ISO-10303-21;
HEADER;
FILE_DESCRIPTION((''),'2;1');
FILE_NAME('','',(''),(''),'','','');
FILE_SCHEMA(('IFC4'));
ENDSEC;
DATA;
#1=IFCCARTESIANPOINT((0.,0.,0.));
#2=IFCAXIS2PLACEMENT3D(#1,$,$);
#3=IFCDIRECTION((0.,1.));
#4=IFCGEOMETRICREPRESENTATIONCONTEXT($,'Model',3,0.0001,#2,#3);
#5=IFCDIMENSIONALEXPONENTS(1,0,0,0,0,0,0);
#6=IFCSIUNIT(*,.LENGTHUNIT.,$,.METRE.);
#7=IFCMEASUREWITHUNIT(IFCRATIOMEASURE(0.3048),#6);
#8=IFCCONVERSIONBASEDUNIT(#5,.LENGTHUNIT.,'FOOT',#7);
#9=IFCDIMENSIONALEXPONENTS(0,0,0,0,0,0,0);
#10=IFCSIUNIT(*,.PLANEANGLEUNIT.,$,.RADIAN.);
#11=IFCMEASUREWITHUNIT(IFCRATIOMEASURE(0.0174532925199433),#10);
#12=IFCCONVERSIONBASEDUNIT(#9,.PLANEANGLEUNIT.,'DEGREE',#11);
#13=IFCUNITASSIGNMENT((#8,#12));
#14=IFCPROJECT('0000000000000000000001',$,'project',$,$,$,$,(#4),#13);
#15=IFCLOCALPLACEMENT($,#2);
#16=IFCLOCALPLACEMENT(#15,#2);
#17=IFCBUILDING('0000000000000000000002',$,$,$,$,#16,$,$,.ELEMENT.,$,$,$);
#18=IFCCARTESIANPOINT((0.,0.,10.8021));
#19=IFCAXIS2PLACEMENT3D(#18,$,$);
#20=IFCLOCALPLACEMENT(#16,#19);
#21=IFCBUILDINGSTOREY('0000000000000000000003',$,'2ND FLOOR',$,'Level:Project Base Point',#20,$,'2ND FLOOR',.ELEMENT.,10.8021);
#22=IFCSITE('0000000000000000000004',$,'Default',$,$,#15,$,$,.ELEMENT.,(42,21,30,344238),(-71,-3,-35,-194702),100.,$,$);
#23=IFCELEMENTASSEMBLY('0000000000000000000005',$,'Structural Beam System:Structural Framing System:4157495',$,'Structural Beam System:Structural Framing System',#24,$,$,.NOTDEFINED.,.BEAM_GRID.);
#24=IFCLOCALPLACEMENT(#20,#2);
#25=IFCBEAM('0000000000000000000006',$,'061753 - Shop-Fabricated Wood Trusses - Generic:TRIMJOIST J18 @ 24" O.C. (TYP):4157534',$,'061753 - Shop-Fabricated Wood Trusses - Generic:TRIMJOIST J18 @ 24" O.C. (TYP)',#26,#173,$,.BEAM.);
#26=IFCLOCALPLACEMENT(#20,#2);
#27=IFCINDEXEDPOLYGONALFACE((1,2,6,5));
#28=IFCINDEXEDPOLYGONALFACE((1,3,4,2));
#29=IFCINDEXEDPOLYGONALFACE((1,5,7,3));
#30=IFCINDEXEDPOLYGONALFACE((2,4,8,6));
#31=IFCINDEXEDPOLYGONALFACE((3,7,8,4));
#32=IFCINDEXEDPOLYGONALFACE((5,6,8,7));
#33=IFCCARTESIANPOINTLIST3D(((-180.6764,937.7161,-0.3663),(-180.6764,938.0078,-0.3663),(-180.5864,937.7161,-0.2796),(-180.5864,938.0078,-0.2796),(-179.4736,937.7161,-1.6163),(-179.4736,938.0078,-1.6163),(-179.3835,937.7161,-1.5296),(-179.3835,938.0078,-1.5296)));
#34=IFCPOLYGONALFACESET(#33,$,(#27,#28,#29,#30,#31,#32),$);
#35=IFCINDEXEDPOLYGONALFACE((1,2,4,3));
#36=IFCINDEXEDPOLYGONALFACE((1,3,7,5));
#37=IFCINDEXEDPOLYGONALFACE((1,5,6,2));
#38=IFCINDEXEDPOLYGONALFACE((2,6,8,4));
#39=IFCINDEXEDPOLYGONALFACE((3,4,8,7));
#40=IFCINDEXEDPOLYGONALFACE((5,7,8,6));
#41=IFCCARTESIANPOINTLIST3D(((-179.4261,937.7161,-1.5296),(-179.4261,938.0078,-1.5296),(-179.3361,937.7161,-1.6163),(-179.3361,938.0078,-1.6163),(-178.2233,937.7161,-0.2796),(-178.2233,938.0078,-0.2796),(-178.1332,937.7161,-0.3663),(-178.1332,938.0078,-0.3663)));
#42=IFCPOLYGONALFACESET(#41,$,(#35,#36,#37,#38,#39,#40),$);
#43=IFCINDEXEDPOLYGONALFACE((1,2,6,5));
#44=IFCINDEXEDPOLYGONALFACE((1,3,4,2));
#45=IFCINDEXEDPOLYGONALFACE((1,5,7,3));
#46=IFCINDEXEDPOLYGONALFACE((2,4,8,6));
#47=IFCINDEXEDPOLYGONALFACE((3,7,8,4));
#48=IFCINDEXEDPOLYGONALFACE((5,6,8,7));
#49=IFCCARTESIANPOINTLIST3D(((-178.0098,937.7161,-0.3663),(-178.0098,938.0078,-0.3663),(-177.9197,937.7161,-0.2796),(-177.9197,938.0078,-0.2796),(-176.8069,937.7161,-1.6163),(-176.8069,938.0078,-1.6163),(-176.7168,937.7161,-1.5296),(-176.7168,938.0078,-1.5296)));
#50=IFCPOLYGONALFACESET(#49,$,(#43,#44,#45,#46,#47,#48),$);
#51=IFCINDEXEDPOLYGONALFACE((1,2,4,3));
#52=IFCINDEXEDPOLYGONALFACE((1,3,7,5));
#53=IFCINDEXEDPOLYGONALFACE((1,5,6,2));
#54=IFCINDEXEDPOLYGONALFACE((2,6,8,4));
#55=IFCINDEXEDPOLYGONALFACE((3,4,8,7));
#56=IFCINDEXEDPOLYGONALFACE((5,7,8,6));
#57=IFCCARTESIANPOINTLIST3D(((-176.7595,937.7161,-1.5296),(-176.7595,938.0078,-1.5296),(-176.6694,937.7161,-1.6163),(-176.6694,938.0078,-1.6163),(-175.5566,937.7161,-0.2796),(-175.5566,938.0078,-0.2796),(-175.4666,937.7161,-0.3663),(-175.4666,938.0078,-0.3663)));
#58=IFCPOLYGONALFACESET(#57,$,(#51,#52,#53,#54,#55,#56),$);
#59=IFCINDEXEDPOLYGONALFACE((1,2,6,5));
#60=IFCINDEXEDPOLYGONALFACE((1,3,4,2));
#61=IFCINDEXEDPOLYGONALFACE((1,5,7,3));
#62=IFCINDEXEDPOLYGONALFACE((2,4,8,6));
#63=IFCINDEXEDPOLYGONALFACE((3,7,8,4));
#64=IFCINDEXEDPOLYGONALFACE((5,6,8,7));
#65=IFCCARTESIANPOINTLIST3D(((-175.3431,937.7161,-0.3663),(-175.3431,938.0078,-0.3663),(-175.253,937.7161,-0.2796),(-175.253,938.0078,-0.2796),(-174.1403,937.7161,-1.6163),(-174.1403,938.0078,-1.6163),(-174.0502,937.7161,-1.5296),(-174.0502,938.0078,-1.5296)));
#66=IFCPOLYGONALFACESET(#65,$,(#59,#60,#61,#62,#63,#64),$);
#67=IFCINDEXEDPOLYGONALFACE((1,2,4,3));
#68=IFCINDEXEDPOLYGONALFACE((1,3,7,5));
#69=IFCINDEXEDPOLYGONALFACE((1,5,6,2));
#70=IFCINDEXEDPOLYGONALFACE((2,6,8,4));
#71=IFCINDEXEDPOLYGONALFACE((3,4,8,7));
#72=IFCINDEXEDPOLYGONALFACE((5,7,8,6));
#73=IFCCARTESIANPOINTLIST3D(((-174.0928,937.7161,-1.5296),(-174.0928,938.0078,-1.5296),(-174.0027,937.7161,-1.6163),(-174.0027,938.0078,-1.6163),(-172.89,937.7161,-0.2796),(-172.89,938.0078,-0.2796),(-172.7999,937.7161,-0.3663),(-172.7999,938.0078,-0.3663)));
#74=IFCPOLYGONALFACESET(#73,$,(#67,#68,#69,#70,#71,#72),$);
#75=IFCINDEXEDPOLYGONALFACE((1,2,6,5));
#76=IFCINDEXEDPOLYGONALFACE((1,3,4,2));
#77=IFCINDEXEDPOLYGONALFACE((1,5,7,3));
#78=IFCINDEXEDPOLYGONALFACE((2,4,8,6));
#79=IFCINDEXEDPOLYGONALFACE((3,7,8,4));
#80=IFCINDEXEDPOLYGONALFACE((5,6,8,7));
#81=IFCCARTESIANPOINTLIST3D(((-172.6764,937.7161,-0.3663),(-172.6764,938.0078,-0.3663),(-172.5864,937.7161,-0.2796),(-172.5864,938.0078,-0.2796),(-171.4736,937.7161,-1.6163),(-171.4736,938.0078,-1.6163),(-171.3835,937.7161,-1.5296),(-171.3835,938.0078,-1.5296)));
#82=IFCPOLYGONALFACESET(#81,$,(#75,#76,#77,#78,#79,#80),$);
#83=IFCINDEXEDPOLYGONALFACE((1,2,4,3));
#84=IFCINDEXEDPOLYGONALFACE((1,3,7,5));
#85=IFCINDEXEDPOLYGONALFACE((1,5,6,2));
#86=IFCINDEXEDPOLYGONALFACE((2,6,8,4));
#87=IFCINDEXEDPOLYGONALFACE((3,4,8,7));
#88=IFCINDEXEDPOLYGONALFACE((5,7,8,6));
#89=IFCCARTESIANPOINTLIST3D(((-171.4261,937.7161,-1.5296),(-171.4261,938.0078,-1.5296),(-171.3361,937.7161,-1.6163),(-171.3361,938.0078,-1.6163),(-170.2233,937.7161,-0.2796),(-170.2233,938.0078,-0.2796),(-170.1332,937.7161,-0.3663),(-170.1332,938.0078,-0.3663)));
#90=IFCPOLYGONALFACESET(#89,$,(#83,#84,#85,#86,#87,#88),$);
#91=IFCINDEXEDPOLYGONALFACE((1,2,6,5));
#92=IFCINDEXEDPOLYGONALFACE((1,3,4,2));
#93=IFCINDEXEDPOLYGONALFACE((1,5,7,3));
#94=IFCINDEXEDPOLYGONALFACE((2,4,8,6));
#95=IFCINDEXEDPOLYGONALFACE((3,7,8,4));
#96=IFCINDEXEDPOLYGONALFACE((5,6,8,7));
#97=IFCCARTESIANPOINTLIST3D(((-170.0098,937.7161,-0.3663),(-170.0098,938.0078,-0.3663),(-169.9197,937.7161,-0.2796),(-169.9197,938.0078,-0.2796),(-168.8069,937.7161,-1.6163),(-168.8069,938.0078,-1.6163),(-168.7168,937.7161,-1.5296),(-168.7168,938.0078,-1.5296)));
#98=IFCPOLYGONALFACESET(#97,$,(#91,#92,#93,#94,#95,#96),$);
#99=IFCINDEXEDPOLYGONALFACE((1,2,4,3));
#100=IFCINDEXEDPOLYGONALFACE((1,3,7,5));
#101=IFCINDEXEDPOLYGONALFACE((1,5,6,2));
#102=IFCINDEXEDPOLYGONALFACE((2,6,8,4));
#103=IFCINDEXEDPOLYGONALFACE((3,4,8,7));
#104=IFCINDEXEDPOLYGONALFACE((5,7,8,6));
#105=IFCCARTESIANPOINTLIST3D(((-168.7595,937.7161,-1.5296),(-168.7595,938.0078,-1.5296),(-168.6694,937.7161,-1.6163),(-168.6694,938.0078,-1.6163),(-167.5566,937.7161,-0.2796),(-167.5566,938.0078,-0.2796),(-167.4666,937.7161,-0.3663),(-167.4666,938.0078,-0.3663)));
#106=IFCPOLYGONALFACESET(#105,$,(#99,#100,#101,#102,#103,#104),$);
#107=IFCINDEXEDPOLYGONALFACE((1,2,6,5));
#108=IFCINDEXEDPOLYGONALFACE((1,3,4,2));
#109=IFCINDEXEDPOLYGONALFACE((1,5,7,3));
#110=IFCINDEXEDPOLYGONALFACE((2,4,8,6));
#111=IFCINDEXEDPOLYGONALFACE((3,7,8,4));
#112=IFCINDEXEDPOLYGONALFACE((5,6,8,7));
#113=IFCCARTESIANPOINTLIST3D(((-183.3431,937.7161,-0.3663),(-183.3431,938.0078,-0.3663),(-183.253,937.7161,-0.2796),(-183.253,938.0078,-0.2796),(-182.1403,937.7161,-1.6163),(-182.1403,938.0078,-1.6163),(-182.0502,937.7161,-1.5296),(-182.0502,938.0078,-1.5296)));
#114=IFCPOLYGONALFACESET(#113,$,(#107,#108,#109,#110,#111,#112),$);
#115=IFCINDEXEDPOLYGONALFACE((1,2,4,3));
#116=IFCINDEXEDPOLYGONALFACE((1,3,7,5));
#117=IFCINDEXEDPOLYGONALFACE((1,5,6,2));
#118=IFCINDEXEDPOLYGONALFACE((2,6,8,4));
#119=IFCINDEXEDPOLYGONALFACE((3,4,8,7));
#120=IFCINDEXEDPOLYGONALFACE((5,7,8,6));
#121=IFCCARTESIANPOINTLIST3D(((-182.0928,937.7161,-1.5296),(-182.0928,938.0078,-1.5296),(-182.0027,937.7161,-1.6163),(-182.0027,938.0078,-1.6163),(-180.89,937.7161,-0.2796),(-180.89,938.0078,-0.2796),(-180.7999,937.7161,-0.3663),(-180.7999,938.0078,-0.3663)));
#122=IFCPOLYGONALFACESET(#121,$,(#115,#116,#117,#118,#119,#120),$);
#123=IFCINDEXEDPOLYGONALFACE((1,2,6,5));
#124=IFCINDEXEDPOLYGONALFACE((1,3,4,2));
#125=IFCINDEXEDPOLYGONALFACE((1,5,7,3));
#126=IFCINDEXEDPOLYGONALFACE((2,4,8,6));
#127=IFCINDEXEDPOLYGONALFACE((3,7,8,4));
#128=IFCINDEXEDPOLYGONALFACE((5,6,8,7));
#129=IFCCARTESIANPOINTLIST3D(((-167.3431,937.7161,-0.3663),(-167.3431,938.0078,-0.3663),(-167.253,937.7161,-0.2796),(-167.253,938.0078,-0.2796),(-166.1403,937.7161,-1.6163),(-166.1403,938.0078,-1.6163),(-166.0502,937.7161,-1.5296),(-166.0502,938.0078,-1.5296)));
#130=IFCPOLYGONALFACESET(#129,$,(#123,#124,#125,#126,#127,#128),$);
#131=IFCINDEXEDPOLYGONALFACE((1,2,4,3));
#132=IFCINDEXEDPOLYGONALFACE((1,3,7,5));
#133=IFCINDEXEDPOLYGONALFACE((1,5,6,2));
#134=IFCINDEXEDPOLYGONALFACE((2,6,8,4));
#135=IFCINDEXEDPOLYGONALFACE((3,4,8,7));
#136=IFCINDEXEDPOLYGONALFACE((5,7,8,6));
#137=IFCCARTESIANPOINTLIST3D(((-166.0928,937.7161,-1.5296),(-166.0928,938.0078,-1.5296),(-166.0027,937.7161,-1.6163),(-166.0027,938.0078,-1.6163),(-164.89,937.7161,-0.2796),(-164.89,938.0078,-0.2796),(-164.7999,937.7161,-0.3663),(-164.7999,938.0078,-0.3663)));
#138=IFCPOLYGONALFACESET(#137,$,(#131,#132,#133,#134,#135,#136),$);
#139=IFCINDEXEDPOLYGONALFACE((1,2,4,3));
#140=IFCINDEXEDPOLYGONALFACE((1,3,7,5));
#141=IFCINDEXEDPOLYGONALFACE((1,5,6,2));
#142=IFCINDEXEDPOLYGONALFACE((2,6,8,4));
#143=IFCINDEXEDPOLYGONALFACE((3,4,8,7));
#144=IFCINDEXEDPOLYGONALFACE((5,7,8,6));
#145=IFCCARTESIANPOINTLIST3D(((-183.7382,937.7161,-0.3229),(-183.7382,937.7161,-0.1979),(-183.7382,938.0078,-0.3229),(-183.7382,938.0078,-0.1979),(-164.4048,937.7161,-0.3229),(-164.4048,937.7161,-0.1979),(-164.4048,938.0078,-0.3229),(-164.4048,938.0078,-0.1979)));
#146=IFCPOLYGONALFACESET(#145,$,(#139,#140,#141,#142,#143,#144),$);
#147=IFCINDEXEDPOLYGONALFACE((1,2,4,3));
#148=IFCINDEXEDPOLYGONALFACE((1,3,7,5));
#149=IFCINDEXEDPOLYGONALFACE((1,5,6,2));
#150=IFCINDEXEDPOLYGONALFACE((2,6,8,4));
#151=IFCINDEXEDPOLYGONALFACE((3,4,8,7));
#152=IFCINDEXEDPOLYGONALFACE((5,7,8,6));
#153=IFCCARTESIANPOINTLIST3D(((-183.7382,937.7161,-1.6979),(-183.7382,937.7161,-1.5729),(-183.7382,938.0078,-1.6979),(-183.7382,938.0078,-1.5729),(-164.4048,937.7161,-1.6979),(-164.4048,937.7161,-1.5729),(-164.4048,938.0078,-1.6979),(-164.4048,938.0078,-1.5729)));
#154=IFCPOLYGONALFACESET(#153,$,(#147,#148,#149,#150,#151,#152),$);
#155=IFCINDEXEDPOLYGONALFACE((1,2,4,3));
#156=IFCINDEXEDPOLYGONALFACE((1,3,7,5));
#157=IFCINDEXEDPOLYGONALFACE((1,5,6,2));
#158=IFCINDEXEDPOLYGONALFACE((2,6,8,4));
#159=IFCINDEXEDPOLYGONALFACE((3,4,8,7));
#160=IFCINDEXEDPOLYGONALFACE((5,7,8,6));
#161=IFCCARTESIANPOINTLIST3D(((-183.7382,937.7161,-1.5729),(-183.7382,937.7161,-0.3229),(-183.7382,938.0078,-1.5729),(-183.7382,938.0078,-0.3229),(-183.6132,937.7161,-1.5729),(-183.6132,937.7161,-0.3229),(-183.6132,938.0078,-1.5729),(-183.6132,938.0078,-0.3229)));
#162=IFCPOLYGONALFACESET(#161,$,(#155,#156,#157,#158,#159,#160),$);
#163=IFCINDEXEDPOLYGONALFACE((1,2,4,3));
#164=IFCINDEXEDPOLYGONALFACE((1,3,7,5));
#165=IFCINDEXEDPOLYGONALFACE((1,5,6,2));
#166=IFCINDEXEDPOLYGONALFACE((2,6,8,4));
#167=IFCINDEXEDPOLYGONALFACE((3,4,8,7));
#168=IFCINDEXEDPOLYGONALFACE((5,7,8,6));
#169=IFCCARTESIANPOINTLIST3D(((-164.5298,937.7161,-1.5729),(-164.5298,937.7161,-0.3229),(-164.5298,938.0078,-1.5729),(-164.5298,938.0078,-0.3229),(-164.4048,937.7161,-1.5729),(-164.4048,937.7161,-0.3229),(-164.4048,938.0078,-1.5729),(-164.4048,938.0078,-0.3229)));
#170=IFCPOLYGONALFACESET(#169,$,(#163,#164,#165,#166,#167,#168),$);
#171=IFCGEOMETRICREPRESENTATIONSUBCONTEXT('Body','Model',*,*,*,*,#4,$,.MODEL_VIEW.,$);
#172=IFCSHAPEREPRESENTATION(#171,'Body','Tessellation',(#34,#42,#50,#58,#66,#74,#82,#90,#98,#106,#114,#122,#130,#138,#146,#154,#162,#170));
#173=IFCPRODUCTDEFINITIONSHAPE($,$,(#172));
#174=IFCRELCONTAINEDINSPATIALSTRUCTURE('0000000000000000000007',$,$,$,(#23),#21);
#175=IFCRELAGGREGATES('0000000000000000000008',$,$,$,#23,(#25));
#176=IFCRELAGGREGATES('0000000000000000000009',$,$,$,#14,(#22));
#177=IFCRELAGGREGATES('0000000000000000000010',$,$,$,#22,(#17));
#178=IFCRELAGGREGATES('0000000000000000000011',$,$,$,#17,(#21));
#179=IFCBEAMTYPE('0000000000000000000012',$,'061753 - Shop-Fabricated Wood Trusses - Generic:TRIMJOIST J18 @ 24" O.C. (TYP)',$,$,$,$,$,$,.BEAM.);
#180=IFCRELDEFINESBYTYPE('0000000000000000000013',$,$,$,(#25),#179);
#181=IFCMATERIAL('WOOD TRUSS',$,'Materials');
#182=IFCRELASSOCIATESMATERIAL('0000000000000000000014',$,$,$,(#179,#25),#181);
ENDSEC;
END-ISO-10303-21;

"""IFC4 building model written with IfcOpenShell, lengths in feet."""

from ifc_helpers import new_model, entity, si_unit, converted_unit, direction, frame, frame_2d, origin, origin_2d_with_axis, place, context, subcontext, project, spatial, rectangle, extrude, source, transform, mapped, material, material_profile, profile_set, profile_usage, type_object, type_shapes, element, aggregate, save


model = new_model("IFC4")

# Units and contexts
model_context = context("Model", 3, precision=0.0001, world=origin(), true_north=direction((0.0, 1.0)))
body_context = subcontext(model_context, "Body", "Model", "MODEL_VIEW")
ifc_project = project(units=[converted_unit("LENGTHUNIT", "FOOT", entity("IfcRatioMeasure", 0.3048), si_unit("LENGTHUNIT", "METRE"), dimensions=[1, 0, 0, 0, 0, 0, 0]), converted_unit("PLANEANGLEUNIT", "DEGREE", entity("IfcRatioMeasure", 0.0174532925199433), si_unit("PLANEANGLEUNIT", "RADIAN"), dimensions=[0, 0, 0, 0, 0, 0, 0])], contexts=[model_context])

# Site, building, storey
site_placement = place(None, origin())
site = spatial("IfcSite", under=ifc_project, at=site_placement, Name="Default", CompositionType="ELEMENT", RefLatitude=(42, 21, 30, 344238), RefLongitude=(-71, -3, -35, -194702), RefElevation=100.0)
building_placement = place(site_placement, origin())
building = spatial("IfcBuilding", under=site, at=building_placement, CompositionType="ELEMENT")
storey_placement = place(building_placement, frame((0.0, 0.0, 10.8021)))
storey = spatial("IfcBuildingStorey", under=building, at=storey_placement, Name="2ND FLOOR", ObjectType="Level:Project Base Point", LongName="2ND FLOOR", CompositionType="ELEMENT", Elevation=10.8021)

# Element assembly, beam
ifc_material_1 = material(Name="WOOD TRUSS", Category="Materials")
ifc_material_profile_1 = material_profile(ifc_material_1, rectangle(XDim=1.7347, YDim=0.125, at=frame_2d((0.0, 0.0), x_axis=(1.0, 0.0))), Name="TRIMJOIST J18 @ 24\" O.C. (TYP)")
ifc_material_profile_2 = material_profile(ifc_material_1, rectangle(XDim=1.7347, YDim=0.125, at=frame_2d((0.0, 0.0), x_axis=(1.0, 0.0))), Name="TRIMJOIST J18 @ 24\" O.C. (TYP)")
ifc_material_profile_3 = material_profile(ifc_material_1, rectangle(XDim=1.7347, YDim=0.125, at=frame_2d((0.0, 0.0), x_axis=(1.0, 0.0))), Name="TRIMJOIST J18 @ 24\" O.C. (TYP)")
ifc_material_profile_4 = material_profile(ifc_material_1, rectangle(XDim=1.7347, YDim=0.125, at=frame_2d((0.0, 0.0), x_axis=(1.0, 0.0))), Name="TRIMJOIST J18 @ 24\" O.C. (TYP)")
ifc_material_profile_5 = material_profile(ifc_material_1, rectangle(XDim=1.7347, YDim=0.125, at=frame_2d((0.0, 0.0), x_axis=(1.0, 0.0))), Name="TRIMJOIST J18 @ 24\" O.C. (TYP)")
ifc_material_profile_6 = material_profile(ifc_material_1, rectangle(XDim=1.7347, YDim=0.125, at=frame_2d((0.0, 0.0), x_axis=(1.0, 0.0))), Name="TRIMJOIST J18 @ 24\" O.C. (TYP)")
ifc_material_profile_7 = material_profile(ifc_material_1, rectangle(XDim=1.7347, YDim=0.125, at=frame_2d((0.0, 0.0), x_axis=(1.0, 0.0))), Name="TRIMJOIST J18 @ 24\" O.C. (TYP)")
ifc_material_profile_8 = material_profile(ifc_material_1, rectangle(XDim=1.7347, YDim=0.125, at=frame_2d((0.0, 0.0), x_axis=(1.0, 0.0))), Name="TRIMJOIST J18 @ 24\" O.C. (TYP)")
ifc_material_profile_9 = material_profile(ifc_material_1, rectangle(XDim=1.7347, YDim=0.125, at=frame_2d((0.0, 0.0), x_axis=(1.0, 0.0))), Name="TRIMJOIST J18 @ 24\" O.C. (TYP)")
ifc_material_profile_10 = material_profile(ifc_material_1, rectangle(XDim=1.7347, YDim=0.125, at=origin_2d_with_axis()), Name="TRIMJOIST J18 @ 24\" O.C. (TYP)")
ifc_material_profile_11 = material_profile(ifc_material_1, rectangle(XDim=0.125, YDim=0.2917, at=origin_2d_with_axis()), Name="TRIMJOIST J18 @ 24\" O.C. (TYP)")
ifc_material_profile_12 = material_profile(ifc_material_1, rectangle(XDim=0.125, YDim=0.2917, at=origin_2d_with_axis()), Name="TRIMJOIST J18 @ 24\" O.C. (TYP)")
ifc_material_profile_13 = material_profile(ifc_material_1, rectangle(XDim=1.25, YDim=0.2917, at=origin_2d_with_axis()), Name="TRIMJOIST J18 @ 24\" O.C. (TYP)")
ifc_material_profile_14 = material_profile(ifc_material_1, rectangle(XDim=1.25, YDim=0.2917, at=origin_2d_with_axis()), Name="TRIMJOIST J18 @ 24\" O.C. (TYP)")
ifc_profile_set_1 = profile_set([ifc_material_profile_1, ifc_material_profile_2, ifc_material_profile_3, ifc_material_profile_4, ifc_material_profile_5, ifc_material_profile_6, ifc_material_profile_7, ifc_material_profile_8, ifc_material_profile_9, ifc_material_profile_10, ifc_material_profile_11, ifc_material_profile_12, ifc_material_profile_13, ifc_material_profile_14], Name="TRIMJOIST J18 @ 24\" O.C. (TYP)")
assembly_1_placement = place(storey_placement, origin())
assembly_1 = element("IfcElementAssembly", 1, at=assembly_1_placement, inside=storey, Name="Structural Beam System:Structural Framing System:4157495", ObjectType="Structural Beam System:Structural Framing System", AssemblyPlace="NOTDEFINED", PredefinedType="BEAM_GRID")
beam_type_1 = type_object("IfcBeamType", Name="061753 - Shop-Fabricated Wood Trusses - Generic:TRIMJOIST J18 @ 24\" O.C. (TYP)", PredefinedType="BEAM", material=ifc_profile_set_1)
shared_shape_1 = source(origin(), body_context, "Body", "SweptSolid", [
    extrude(rectangle(XDim=1.7347, YDim=0.125, at=frame_2d((0.0, 0.0), x_axis=(1.0, 0.0))), frame((5.9585, -0.1458, 0.0), z_axis=(0.0, 1.0, 0.0), x_axis=(0.693383, 0.0, 0.720569)), (0.0, 0.0, 1.0), 0.2917),
    extrude(rectangle(XDim=1.7347, YDim=0.125, at=origin_2d_with_axis()), frame((4.7082, -0.1458, 0.0), z_axis=(0.0, 1.0, 0.0), x_axis=(0.693383, 0.0, -0.720569)), (0.0, 0.0, 1.0), 0.2917),
    extrude(rectangle(XDim=1.7347, YDim=0.125, at=frame_2d((0.0, 0.0), x_axis=(1.0, 0.0))), frame((3.2918, -0.1458, 0.0), z_axis=(0.0, 1.0, 0.0), x_axis=(0.693383, 0.0, 0.720569)), (0.0, 0.0, 1.0), 0.2917),
    extrude(rectangle(XDim=1.7347, YDim=0.125, at=frame_2d((0.0, 0.0), x_axis=(1.0, 0.0))), frame((2.0415, -0.1458, 0.0), z_axis=(0.0, 1.0, 0.0), x_axis=(0.693383, 0.0, -0.720569)), (0.0, 0.0, 1.0), 0.2917),
    extrude(rectangle(XDim=1.7347, YDim=0.125, at=frame_2d((0.0, 0.0), x_axis=(1.0, 0.0))), frame((0.6251, -0.1458, 0.0), z_axis=(0.0, 1.0, 0.0), x_axis=(0.693383, 0.0, 0.720569)), (0.0, 0.0, 1.0), 0.2917),
    extrude(rectangle(XDim=1.7347, YDim=0.125, at=frame_2d((0.0, 0.0), x_axis=(1.0, 0.0))), frame((-0.6251, -0.1458, 0.0), z_axis=(0.0, 1.0, 0.0), x_axis=(0.693383, 0.0, -0.720569)), (0.0, 0.0, 1.0), 0.2917),
    extrude(rectangle(XDim=1.7347, YDim=0.125, at=frame_2d((0.0, 0.0), x_axis=(1.0, 0.0))), frame((-2.0415, -0.1458, 0.0), z_axis=(0.0, 1.0, 0.0), x_axis=(0.693383, 0.0, 0.720569)), (0.0, 0.0, 1.0), 0.2917),
    extrude(rectangle(XDim=1.7347, YDim=0.125, at=origin_2d_with_axis()), frame((-3.2918, -0.1458, 0.0), z_axis=(0.0, 1.0, 0.0), x_axis=(0.693383, 0.0, -0.720569)), (0.0, 0.0, 1.0), 0.2917),
    extrude(rectangle(XDim=1.7347, YDim=0.125, at=frame_2d((0.0, 0.0), x_axis=(1.0, 0.0))), frame((-4.7082, -0.1458, 0.0), z_axis=(0.0, 1.0, 0.0), x_axis=(0.693383, 0.0, 0.720569)), (0.0, 0.0, 1.0), 0.2917),
    extrude(rectangle(XDim=1.7347, YDim=0.125, at=frame_2d((0.0, 0.0), x_axis=(1.0, 0.0))), frame((-5.9585, -0.1458, 0.0), z_axis=(0.0, 1.0, 0.0), x_axis=(0.693383, 0.0, -0.720569)), (0.0, 0.0, 1.0), 0.2917),
    extrude(rectangle(XDim=1.7347, YDim=0.125, at=frame_2d((0.0, 0.0), x_axis=(1.0, 0.0))), frame((8.6251, -0.1458, 0.0), z_axis=(0.0, 1.0, 0.0), x_axis=(0.693383, 0.0, 0.720569)), (0.0, 0.0, 1.0), 0.2917),
    extrude(rectangle(XDim=1.7347, YDim=0.125, at=origin_2d_with_axis()), frame((7.3749, -0.1458, 0.0), z_axis=(0.0, 1.0, 0.0), x_axis=(0.693383, 0.0, -0.720569)), (0.0, 0.0, 1.0), 0.2917),
    extrude(rectangle(XDim=1.7347, YDim=0.125, at=frame_2d((0.0, 0.0), x_axis=(1.0, 0.0))), frame((-7.3749, -0.1458, 0.0), z_axis=(0.0, 1.0, 0.0), x_axis=(0.693383, 0.0, 0.720569)), (0.0, 0.0, 1.0), 0.2917),
    extrude(rectangle(XDim=1.7347, YDim=0.125, at=origin_2d_with_axis()), frame((-8.6251, -0.1458, 0.0), z_axis=(0.0, 1.0, 0.0), x_axis=(0.693383, 0.0, -0.720569)), (0.0, 0.0, 1.0), 0.2917),
    extrude(rectangle(XDim=0.125, YDim=0.2917, at=origin_2d_with_axis()), frame((-9.6667, 0.0, 0.6875), z_axis=(1.0, 0.0, 0.0), x_axis=(0.0, 0.0, -1.0)), (0.0, 0.0, 1.0), 19.3333),
    extrude(rectangle(XDim=0.125, YDim=0.2917, at=origin_2d_with_axis()), frame((-9.6667, 0.0, -0.6875), z_axis=(1.0, 0.0, 0.0), x_axis=(0.0, 0.0, -1.0)), (0.0, 0.0, 1.0), 19.3333),
    extrude(rectangle(XDim=1.25, YDim=0.2917, at=origin_2d_with_axis()), frame((9.5417, 0.0, 0.0), z_axis=(1.0, 0.0, 0.0), x_axis=(0.0, 0.0, -1.0)), (0.0, 0.0, 1.0), 0.125),
    extrude(rectangle(XDim=1.25, YDim=0.2917, at=origin_2d_with_axis()), frame((-9.6667, 0.0, 0.0), z_axis=(1.0, 0.0, 0.0), x_axis=(0.0, 0.0, -1.0)), (0.0, 0.0, 1.0), 0.125),
])
type_shapes(beam_type_1, [shared_shape_1])
ifc_profile_usage_1 = profile_usage(ifc_profile_set_1, cardinal=8)
beam_1_placement = place(assembly_1_placement, frame((-174.0715, 937.8619, -0.9479), z_axis=(0.0, 0.0, 1.0), x_axis=(-1.0, 0.0, 0.0)))
beam_1 = element("IfcBeam", 2, at=beam_1_placement, type_object=beam_type_1, material=ifc_profile_usage_1, Name="061753 - Shop-Fabricated Wood Trusses - Generic:TRIMJOIST J18 @ 24\" O.C. (TYP):4157534", ObjectType="061753 - Shop-Fabricated Wood Trusses - Generic:TRIMJOIST J18 @ 24\" O.C. (TYP)", PredefinedType="BEAM", context=body_context, shape_type="MappedRepresentation", body=[
    mapped(shared_shape_1, transform((0.0, 0.0, 0.0), scale=1.0)),
])
aggregate(assembly_1, [beam_1])

save(model, "model.ifc")
